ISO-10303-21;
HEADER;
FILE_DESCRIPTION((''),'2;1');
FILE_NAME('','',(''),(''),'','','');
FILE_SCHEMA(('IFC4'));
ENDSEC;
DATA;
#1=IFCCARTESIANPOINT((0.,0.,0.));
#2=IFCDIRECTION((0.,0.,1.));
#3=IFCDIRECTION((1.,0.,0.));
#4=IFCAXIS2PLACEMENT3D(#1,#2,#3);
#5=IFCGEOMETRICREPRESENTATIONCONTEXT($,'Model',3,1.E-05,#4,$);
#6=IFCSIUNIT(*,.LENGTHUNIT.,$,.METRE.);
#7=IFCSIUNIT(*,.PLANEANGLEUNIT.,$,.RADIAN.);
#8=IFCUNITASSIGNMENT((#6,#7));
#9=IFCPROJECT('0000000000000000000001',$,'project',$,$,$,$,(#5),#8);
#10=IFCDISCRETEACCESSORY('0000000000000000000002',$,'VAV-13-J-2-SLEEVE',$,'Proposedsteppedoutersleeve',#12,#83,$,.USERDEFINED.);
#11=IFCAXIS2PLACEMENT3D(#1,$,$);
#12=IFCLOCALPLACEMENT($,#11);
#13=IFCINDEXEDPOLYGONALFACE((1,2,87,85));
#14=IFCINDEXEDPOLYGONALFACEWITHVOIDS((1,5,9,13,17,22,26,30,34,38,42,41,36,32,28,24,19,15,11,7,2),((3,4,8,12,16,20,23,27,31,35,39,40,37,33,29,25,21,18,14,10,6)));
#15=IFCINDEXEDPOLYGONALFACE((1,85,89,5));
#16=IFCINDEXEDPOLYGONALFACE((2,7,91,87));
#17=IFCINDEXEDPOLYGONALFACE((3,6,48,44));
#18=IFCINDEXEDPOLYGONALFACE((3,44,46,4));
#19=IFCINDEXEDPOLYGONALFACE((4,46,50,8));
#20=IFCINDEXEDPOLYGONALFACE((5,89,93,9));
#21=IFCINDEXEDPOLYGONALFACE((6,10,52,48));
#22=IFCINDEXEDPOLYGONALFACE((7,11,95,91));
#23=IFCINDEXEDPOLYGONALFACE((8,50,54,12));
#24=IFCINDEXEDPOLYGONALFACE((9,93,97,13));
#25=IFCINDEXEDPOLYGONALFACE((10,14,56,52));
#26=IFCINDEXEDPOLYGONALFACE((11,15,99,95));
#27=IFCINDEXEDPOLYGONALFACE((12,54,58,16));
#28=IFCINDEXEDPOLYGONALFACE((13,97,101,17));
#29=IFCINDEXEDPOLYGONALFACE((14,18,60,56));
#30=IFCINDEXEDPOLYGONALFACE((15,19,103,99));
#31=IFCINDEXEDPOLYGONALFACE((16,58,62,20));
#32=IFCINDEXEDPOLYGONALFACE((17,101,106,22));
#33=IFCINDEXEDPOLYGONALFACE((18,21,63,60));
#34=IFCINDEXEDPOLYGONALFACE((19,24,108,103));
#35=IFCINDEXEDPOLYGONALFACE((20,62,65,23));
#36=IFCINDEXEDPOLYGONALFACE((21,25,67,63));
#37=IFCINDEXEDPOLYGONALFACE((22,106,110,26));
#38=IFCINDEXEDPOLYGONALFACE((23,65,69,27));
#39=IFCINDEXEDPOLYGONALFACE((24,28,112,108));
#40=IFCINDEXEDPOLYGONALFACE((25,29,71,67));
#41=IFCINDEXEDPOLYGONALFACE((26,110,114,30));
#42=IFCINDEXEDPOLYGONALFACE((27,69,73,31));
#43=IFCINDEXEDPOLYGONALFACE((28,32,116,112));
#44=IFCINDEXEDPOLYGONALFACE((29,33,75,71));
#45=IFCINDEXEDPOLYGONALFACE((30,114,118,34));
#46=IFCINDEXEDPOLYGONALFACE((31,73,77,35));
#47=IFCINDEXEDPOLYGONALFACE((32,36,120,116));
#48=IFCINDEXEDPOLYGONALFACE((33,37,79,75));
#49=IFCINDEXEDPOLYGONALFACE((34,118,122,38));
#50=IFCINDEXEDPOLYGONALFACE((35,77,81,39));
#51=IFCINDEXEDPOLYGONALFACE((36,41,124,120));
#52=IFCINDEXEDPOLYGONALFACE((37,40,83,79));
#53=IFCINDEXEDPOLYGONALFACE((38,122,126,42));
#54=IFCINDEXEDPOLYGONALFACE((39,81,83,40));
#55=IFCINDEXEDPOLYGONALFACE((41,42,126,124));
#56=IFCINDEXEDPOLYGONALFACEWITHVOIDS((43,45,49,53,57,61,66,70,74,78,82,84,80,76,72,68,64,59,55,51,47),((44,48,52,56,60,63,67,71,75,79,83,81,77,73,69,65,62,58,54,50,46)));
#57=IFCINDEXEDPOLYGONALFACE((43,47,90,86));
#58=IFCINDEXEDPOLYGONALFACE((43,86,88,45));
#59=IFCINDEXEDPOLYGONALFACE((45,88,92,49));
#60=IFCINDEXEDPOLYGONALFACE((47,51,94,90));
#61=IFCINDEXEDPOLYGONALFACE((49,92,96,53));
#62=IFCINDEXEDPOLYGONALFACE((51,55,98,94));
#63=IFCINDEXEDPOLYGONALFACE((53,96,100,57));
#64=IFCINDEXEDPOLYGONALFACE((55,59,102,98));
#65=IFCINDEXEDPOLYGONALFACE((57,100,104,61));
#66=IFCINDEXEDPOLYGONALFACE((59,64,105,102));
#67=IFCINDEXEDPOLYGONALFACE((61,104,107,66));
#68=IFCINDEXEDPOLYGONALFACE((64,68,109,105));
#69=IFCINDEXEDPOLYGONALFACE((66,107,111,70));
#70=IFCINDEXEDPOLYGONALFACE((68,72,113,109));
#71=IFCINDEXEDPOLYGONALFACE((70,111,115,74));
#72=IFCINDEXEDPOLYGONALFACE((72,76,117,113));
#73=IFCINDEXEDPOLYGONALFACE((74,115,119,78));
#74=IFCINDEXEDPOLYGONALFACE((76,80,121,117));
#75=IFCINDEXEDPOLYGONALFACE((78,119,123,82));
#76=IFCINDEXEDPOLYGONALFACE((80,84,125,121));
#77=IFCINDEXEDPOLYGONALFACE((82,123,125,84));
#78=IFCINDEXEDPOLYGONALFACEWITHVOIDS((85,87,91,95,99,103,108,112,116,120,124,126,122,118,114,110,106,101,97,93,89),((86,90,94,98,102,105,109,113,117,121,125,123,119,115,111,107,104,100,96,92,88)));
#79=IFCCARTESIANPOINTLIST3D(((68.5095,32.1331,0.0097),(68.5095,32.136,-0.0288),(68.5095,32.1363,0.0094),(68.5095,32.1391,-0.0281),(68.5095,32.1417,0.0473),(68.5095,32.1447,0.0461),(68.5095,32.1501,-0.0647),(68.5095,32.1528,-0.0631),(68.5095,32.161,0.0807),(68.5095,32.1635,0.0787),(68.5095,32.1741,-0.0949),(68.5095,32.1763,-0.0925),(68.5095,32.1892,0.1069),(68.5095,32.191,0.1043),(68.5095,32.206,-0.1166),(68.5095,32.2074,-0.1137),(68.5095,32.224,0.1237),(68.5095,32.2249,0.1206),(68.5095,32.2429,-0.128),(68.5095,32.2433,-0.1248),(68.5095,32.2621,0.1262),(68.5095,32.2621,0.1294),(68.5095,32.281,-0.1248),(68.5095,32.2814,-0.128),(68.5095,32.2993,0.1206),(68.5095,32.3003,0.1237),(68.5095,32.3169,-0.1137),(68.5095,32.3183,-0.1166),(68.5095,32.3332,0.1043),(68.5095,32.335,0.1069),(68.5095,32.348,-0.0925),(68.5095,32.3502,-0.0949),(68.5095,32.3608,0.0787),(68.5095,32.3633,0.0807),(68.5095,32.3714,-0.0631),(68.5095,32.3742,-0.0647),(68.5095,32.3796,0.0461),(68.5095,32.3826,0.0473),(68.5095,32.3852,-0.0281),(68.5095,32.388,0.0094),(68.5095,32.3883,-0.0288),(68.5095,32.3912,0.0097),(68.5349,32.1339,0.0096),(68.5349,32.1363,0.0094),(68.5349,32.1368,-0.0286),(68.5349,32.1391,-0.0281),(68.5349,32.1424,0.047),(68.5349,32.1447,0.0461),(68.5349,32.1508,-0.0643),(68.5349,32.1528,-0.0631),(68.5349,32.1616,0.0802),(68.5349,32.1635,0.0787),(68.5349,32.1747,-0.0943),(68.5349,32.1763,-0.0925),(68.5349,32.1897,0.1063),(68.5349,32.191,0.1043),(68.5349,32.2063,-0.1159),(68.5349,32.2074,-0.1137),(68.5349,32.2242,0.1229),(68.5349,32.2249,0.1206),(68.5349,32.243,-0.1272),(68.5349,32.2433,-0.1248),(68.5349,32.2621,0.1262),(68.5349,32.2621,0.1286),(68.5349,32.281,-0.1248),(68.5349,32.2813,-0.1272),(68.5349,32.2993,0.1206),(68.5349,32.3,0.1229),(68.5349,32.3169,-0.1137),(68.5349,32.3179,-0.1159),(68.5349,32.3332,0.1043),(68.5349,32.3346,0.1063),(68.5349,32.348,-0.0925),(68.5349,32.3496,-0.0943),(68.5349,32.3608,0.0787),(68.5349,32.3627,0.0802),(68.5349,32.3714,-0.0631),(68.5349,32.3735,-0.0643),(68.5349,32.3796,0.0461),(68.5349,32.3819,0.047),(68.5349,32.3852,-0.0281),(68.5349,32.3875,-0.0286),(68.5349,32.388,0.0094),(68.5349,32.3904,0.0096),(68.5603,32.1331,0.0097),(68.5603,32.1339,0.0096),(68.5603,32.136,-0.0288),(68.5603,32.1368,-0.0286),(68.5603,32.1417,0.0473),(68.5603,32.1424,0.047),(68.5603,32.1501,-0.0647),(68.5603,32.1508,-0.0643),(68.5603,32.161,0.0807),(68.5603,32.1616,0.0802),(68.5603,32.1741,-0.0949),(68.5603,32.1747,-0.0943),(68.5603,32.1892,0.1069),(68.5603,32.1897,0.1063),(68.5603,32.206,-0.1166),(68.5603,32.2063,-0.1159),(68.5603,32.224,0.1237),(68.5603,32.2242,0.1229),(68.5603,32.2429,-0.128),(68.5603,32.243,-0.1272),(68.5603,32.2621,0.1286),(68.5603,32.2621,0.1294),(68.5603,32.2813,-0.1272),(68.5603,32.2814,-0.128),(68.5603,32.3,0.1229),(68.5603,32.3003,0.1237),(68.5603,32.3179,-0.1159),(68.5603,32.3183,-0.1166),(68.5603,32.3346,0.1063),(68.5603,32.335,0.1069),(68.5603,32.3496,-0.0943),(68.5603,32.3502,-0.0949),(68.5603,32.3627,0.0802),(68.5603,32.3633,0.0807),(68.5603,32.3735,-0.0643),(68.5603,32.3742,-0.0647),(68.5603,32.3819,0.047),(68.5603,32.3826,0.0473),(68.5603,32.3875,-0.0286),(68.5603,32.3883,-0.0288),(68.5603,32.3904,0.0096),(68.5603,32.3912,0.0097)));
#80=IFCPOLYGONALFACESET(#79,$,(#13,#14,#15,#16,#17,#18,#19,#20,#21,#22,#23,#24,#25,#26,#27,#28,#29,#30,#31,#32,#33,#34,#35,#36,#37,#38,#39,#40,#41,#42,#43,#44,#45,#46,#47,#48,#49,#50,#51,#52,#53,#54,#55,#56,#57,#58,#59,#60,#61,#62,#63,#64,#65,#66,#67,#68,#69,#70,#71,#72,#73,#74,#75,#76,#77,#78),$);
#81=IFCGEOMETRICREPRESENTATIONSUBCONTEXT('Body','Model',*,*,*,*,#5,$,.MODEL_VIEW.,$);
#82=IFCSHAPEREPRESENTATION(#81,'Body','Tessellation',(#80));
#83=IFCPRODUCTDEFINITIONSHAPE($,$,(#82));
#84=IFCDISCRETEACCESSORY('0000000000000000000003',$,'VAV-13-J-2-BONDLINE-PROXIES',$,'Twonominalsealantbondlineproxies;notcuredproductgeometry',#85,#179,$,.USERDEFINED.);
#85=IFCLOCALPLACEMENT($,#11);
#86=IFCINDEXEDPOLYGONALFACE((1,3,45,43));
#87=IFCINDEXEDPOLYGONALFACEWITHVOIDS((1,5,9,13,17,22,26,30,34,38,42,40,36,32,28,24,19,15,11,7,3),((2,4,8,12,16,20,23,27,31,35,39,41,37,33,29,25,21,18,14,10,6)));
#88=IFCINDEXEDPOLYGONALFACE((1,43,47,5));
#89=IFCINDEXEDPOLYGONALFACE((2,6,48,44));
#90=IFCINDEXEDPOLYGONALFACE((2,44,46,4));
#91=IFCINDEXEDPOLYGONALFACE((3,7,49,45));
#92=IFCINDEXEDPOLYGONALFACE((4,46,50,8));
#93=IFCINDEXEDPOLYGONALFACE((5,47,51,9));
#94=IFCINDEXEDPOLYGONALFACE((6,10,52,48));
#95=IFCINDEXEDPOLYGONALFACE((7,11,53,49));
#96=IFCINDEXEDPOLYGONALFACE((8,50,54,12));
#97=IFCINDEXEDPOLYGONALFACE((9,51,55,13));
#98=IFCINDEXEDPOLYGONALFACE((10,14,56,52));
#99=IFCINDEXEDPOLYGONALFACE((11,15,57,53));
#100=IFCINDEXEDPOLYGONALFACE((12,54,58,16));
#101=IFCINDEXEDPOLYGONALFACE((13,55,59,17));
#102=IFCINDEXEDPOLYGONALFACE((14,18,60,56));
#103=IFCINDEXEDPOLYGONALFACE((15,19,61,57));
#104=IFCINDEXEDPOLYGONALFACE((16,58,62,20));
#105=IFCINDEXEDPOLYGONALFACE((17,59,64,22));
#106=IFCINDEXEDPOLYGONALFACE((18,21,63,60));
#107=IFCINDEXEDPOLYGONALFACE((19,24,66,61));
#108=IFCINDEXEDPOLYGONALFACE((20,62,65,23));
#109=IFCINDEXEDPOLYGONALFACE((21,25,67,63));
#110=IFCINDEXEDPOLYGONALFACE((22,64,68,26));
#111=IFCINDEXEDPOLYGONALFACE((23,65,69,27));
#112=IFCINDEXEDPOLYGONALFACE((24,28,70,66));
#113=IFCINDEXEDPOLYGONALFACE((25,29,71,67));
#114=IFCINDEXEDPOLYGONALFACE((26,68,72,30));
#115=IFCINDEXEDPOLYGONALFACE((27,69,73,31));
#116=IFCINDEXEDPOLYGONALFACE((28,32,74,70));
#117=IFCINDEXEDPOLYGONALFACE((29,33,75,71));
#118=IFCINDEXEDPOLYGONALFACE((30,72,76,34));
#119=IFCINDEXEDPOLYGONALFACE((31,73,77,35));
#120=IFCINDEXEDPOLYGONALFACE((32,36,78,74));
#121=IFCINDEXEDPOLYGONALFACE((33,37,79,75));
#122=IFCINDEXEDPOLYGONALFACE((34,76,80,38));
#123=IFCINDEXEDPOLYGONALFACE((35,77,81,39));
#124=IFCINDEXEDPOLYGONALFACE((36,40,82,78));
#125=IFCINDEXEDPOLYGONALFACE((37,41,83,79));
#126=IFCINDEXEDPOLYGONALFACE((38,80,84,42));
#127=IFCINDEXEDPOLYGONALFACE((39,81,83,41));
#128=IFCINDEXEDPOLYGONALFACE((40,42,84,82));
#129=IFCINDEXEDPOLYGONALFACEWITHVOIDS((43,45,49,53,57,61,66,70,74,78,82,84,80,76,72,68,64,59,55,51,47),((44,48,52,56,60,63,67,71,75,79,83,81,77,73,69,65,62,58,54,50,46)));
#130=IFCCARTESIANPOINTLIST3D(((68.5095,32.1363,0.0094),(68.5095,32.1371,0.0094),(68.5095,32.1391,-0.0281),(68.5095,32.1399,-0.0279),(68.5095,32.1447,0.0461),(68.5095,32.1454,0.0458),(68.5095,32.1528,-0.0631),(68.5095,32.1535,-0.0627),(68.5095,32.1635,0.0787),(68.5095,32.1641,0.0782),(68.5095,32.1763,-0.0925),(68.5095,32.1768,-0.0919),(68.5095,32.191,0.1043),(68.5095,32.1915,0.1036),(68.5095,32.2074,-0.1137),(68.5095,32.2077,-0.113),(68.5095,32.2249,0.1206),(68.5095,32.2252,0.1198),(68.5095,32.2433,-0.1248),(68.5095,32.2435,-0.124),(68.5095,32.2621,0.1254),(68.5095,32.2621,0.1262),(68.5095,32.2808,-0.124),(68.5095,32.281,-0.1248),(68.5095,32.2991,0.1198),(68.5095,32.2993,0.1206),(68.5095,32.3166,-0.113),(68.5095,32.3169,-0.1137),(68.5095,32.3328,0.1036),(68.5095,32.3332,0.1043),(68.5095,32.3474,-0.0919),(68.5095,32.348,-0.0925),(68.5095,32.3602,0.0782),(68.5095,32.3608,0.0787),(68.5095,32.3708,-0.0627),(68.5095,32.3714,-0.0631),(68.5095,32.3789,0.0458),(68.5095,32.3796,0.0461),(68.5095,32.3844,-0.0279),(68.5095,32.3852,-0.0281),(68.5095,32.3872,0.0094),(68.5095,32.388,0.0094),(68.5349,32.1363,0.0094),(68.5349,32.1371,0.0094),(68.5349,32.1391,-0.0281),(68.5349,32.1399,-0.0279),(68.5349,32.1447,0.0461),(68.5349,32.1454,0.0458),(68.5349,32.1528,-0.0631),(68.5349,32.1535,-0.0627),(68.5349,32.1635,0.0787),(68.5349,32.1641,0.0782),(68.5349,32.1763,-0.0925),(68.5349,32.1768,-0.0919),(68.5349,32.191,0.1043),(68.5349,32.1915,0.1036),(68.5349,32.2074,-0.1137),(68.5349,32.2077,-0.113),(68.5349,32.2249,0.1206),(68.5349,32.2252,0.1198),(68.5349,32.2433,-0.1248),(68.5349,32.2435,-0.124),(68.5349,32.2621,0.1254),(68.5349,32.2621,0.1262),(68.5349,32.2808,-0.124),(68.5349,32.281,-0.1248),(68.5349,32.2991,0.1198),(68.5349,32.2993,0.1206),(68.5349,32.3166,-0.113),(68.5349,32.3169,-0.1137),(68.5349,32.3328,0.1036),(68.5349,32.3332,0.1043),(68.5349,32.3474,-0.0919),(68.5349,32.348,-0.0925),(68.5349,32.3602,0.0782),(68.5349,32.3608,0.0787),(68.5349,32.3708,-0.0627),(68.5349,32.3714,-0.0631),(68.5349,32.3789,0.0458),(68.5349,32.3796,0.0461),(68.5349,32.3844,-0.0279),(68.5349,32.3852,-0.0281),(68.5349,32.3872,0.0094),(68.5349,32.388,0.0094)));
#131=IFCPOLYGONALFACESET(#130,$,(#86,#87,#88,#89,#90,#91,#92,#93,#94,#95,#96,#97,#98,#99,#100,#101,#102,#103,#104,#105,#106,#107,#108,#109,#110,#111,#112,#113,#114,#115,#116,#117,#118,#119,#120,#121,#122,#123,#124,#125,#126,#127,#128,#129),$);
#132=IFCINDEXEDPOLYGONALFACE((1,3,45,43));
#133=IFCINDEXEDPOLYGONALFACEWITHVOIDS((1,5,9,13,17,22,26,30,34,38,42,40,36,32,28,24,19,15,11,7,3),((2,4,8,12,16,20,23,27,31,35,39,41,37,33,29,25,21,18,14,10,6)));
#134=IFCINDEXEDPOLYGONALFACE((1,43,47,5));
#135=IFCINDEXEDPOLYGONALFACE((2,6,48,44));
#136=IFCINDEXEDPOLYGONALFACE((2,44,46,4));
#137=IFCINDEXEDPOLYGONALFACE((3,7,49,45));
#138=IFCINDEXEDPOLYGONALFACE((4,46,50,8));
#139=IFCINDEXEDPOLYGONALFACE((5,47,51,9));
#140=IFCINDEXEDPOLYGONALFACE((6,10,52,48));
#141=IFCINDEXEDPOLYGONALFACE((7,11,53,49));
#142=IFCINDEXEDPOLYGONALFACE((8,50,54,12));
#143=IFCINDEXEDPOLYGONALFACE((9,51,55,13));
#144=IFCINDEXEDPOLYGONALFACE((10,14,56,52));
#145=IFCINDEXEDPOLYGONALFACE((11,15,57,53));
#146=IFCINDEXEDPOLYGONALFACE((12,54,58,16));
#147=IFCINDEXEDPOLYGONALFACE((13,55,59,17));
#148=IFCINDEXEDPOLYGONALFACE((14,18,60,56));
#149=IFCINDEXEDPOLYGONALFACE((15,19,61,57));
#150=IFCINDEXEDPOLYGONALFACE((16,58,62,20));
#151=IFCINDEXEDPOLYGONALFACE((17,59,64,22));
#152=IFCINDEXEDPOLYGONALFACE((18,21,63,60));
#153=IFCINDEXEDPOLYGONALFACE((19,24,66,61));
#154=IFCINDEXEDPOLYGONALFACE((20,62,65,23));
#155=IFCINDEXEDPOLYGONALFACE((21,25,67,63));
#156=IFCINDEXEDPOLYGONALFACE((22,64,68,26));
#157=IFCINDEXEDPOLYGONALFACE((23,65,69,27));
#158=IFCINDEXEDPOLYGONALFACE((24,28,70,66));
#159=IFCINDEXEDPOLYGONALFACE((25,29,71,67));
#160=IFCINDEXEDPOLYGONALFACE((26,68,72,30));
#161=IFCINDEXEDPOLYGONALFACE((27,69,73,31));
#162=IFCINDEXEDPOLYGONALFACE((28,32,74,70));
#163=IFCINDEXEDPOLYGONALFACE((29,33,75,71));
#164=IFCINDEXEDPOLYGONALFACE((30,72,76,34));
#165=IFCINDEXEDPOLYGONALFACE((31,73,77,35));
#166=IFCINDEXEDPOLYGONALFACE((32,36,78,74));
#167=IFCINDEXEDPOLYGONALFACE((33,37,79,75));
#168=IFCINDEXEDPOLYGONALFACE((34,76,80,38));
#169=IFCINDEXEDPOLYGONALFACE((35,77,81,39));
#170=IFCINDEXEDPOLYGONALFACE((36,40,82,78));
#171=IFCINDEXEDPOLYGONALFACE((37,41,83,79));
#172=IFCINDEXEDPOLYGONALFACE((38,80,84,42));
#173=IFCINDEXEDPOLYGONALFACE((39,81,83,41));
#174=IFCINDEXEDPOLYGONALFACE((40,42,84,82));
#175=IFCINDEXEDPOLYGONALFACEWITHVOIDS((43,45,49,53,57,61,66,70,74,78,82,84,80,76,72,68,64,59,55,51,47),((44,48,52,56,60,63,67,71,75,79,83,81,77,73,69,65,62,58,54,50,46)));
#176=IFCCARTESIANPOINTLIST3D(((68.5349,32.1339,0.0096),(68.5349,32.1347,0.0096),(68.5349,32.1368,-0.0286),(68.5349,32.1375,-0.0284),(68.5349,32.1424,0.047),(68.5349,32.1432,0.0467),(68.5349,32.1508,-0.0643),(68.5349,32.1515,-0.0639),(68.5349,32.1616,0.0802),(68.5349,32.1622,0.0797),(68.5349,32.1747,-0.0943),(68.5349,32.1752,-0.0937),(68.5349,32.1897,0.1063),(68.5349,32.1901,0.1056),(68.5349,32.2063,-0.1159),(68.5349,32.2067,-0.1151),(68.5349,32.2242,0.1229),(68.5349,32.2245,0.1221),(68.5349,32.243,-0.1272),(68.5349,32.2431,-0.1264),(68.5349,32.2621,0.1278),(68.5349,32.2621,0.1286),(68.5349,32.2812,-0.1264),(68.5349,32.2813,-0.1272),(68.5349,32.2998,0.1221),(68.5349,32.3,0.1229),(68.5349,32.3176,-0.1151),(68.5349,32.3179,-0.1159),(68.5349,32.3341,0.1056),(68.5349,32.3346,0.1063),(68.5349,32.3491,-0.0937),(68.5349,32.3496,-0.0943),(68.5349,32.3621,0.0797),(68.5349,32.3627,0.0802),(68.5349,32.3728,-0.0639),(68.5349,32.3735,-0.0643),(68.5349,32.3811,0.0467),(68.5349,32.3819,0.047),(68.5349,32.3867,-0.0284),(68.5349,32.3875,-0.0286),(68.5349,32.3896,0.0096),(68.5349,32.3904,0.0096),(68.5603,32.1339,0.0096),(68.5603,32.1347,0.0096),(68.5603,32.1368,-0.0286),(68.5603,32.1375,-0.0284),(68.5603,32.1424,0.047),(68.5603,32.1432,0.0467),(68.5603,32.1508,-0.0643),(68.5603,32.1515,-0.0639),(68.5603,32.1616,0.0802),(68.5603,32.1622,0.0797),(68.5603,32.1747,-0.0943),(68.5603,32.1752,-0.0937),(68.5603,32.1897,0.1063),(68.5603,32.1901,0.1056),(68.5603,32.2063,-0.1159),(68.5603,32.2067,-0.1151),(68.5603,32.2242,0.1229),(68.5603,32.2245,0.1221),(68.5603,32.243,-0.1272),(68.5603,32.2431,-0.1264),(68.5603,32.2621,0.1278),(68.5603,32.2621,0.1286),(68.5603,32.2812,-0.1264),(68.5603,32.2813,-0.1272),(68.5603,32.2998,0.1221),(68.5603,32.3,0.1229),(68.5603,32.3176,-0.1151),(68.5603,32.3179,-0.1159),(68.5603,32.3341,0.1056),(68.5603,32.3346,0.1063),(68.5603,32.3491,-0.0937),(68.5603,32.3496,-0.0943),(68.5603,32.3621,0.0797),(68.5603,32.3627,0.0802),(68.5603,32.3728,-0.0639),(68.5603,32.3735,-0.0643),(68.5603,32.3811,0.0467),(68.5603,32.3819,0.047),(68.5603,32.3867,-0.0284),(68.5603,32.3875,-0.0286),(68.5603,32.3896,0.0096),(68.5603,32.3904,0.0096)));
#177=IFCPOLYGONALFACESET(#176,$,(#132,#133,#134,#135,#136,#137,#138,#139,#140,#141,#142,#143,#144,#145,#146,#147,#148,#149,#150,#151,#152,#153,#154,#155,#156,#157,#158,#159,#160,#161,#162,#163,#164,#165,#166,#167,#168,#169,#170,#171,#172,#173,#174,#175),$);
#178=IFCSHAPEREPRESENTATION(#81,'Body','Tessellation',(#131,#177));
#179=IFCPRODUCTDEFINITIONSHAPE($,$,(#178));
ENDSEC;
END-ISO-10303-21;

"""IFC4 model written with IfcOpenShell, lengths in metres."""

from ifc_helpers import new_model, entity, si_unit, frame, origin_with_axes, place, context, subcontext, project, element, save


model = new_model("IFC4")

# Units and contexts
model_context = context("Model", 3, precision=1e-05, world=origin_with_axes())
body_context = subcontext(model_context, "Body", "Model", "MODEL_VIEW")
ifc_project = project(units=[si_unit("LENGTHUNIT", "METRE"), si_unit("PLANEANGLEUNIT", "RADIAN")], contexts=[model_context])

# Discrete accessories
discrete_accessory_1_placement = place(None, frame((68.5349, 32.2621, 0.0), z_axis=(0.0, 1.0, 0.0), x_axis=(0.0, 0.0, 1.0)))
element("IfcDiscreteAccessory", 1, at=discrete_accessory_1_placement, Name="VAV-13-J-2-SLEEVE", ObjectType="Proposedsteppedoutersleeve", PredefinedType="USERDEFINED", context=body_context, shape_type="SweptSolid", body=[
    entity("IfcRevolvedAreaSolid", entity("IfcArbitraryClosedProfileDef", "AREA", None, entity("IfcPolyline", [entity("IfcCartesianPoint", [0.1262, -0.0254]), entity("IfcCartesianPoint", [0.1294, -0.0254]), entity("IfcCartesianPoint", [0.1294, 0.0254]), entity("IfcCartesianPoint", [0.1286, 0.0254]), entity("IfcCartesianPoint", [0.1286, 0.0]), entity("IfcCartesianPoint", [0.1262, 0.0]), entity("IfcCartesianPoint", [0.1262, -0.0254])])), entity("IfcAxis2Placement3D", entity("IfcCartesianPoint", [0.0, 0.0, 0.0])), entity("IfcAxis1Placement", entity("IfcCartesianPoint", [0.0, 0.0, 0.0]), entity("IfcDirection", [0.0, 1.0, 0.0])), 6.283185),
])
discrete_accessory_2_placement = place(None, frame((68.5349, 32.2621, 0.0), z_axis=(0.0, 1.0, 0.0), x_axis=(0.0, 0.0, 1.0)))
element("IfcDiscreteAccessory", 2, at=discrete_accessory_2_placement, Name="VAV-13-J-2-BONDLINE-PROXIES", ObjectType="Twonominalsealantbondlineproxies;notcuredproductgeometry", PredefinedType="USERDEFINED", context=body_context, shape_type="SweptSolid", body=[
    entity("IfcRevolvedAreaSolid", entity("IfcArbitraryClosedProfileDef", "AREA", None, entity("IfcPolyline", [entity("IfcCartesianPoint", [0.1254, -0.0254]), entity("IfcCartesianPoint", [0.1262, -0.0254]), entity("IfcCartesianPoint", [0.1262, 0.0]), entity("IfcCartesianPoint", [0.1254, 0.0]), entity("IfcCartesianPoint", [0.1254, -0.0254])])), entity("IfcAxis2Placement3D", entity("IfcCartesianPoint", [0.0, 0.0, 0.0])), entity("IfcAxis1Placement", entity("IfcCartesianPoint", [0.0, 0.0, 0.0]), entity("IfcDirection", [0.0, 1.0, 0.0])), 6.283185),
    entity("IfcRevolvedAreaSolid", entity("IfcArbitraryClosedProfileDef", "AREA", None, entity("IfcPolyline", [entity("IfcCartesianPoint", [0.1278, 0.0]), entity("IfcCartesianPoint", [0.1286, 0.0]), entity("IfcCartesianPoint", [0.1286, 0.0254]), entity("IfcCartesianPoint", [0.1278, 0.0254]), entity("IfcCartesianPoint", [0.1278, 0.0])])), entity("IfcAxis2Placement3D", entity("IfcCartesianPoint", [0.0, 0.0, 0.0])), entity("IfcAxis1Placement", entity("IfcCartesianPoint", [0.0, 0.0, 0.0]), entity("IfcDirection", [0.0, 1.0, 0.0])), 6.283185),
])

save(model, "model.ifc")
